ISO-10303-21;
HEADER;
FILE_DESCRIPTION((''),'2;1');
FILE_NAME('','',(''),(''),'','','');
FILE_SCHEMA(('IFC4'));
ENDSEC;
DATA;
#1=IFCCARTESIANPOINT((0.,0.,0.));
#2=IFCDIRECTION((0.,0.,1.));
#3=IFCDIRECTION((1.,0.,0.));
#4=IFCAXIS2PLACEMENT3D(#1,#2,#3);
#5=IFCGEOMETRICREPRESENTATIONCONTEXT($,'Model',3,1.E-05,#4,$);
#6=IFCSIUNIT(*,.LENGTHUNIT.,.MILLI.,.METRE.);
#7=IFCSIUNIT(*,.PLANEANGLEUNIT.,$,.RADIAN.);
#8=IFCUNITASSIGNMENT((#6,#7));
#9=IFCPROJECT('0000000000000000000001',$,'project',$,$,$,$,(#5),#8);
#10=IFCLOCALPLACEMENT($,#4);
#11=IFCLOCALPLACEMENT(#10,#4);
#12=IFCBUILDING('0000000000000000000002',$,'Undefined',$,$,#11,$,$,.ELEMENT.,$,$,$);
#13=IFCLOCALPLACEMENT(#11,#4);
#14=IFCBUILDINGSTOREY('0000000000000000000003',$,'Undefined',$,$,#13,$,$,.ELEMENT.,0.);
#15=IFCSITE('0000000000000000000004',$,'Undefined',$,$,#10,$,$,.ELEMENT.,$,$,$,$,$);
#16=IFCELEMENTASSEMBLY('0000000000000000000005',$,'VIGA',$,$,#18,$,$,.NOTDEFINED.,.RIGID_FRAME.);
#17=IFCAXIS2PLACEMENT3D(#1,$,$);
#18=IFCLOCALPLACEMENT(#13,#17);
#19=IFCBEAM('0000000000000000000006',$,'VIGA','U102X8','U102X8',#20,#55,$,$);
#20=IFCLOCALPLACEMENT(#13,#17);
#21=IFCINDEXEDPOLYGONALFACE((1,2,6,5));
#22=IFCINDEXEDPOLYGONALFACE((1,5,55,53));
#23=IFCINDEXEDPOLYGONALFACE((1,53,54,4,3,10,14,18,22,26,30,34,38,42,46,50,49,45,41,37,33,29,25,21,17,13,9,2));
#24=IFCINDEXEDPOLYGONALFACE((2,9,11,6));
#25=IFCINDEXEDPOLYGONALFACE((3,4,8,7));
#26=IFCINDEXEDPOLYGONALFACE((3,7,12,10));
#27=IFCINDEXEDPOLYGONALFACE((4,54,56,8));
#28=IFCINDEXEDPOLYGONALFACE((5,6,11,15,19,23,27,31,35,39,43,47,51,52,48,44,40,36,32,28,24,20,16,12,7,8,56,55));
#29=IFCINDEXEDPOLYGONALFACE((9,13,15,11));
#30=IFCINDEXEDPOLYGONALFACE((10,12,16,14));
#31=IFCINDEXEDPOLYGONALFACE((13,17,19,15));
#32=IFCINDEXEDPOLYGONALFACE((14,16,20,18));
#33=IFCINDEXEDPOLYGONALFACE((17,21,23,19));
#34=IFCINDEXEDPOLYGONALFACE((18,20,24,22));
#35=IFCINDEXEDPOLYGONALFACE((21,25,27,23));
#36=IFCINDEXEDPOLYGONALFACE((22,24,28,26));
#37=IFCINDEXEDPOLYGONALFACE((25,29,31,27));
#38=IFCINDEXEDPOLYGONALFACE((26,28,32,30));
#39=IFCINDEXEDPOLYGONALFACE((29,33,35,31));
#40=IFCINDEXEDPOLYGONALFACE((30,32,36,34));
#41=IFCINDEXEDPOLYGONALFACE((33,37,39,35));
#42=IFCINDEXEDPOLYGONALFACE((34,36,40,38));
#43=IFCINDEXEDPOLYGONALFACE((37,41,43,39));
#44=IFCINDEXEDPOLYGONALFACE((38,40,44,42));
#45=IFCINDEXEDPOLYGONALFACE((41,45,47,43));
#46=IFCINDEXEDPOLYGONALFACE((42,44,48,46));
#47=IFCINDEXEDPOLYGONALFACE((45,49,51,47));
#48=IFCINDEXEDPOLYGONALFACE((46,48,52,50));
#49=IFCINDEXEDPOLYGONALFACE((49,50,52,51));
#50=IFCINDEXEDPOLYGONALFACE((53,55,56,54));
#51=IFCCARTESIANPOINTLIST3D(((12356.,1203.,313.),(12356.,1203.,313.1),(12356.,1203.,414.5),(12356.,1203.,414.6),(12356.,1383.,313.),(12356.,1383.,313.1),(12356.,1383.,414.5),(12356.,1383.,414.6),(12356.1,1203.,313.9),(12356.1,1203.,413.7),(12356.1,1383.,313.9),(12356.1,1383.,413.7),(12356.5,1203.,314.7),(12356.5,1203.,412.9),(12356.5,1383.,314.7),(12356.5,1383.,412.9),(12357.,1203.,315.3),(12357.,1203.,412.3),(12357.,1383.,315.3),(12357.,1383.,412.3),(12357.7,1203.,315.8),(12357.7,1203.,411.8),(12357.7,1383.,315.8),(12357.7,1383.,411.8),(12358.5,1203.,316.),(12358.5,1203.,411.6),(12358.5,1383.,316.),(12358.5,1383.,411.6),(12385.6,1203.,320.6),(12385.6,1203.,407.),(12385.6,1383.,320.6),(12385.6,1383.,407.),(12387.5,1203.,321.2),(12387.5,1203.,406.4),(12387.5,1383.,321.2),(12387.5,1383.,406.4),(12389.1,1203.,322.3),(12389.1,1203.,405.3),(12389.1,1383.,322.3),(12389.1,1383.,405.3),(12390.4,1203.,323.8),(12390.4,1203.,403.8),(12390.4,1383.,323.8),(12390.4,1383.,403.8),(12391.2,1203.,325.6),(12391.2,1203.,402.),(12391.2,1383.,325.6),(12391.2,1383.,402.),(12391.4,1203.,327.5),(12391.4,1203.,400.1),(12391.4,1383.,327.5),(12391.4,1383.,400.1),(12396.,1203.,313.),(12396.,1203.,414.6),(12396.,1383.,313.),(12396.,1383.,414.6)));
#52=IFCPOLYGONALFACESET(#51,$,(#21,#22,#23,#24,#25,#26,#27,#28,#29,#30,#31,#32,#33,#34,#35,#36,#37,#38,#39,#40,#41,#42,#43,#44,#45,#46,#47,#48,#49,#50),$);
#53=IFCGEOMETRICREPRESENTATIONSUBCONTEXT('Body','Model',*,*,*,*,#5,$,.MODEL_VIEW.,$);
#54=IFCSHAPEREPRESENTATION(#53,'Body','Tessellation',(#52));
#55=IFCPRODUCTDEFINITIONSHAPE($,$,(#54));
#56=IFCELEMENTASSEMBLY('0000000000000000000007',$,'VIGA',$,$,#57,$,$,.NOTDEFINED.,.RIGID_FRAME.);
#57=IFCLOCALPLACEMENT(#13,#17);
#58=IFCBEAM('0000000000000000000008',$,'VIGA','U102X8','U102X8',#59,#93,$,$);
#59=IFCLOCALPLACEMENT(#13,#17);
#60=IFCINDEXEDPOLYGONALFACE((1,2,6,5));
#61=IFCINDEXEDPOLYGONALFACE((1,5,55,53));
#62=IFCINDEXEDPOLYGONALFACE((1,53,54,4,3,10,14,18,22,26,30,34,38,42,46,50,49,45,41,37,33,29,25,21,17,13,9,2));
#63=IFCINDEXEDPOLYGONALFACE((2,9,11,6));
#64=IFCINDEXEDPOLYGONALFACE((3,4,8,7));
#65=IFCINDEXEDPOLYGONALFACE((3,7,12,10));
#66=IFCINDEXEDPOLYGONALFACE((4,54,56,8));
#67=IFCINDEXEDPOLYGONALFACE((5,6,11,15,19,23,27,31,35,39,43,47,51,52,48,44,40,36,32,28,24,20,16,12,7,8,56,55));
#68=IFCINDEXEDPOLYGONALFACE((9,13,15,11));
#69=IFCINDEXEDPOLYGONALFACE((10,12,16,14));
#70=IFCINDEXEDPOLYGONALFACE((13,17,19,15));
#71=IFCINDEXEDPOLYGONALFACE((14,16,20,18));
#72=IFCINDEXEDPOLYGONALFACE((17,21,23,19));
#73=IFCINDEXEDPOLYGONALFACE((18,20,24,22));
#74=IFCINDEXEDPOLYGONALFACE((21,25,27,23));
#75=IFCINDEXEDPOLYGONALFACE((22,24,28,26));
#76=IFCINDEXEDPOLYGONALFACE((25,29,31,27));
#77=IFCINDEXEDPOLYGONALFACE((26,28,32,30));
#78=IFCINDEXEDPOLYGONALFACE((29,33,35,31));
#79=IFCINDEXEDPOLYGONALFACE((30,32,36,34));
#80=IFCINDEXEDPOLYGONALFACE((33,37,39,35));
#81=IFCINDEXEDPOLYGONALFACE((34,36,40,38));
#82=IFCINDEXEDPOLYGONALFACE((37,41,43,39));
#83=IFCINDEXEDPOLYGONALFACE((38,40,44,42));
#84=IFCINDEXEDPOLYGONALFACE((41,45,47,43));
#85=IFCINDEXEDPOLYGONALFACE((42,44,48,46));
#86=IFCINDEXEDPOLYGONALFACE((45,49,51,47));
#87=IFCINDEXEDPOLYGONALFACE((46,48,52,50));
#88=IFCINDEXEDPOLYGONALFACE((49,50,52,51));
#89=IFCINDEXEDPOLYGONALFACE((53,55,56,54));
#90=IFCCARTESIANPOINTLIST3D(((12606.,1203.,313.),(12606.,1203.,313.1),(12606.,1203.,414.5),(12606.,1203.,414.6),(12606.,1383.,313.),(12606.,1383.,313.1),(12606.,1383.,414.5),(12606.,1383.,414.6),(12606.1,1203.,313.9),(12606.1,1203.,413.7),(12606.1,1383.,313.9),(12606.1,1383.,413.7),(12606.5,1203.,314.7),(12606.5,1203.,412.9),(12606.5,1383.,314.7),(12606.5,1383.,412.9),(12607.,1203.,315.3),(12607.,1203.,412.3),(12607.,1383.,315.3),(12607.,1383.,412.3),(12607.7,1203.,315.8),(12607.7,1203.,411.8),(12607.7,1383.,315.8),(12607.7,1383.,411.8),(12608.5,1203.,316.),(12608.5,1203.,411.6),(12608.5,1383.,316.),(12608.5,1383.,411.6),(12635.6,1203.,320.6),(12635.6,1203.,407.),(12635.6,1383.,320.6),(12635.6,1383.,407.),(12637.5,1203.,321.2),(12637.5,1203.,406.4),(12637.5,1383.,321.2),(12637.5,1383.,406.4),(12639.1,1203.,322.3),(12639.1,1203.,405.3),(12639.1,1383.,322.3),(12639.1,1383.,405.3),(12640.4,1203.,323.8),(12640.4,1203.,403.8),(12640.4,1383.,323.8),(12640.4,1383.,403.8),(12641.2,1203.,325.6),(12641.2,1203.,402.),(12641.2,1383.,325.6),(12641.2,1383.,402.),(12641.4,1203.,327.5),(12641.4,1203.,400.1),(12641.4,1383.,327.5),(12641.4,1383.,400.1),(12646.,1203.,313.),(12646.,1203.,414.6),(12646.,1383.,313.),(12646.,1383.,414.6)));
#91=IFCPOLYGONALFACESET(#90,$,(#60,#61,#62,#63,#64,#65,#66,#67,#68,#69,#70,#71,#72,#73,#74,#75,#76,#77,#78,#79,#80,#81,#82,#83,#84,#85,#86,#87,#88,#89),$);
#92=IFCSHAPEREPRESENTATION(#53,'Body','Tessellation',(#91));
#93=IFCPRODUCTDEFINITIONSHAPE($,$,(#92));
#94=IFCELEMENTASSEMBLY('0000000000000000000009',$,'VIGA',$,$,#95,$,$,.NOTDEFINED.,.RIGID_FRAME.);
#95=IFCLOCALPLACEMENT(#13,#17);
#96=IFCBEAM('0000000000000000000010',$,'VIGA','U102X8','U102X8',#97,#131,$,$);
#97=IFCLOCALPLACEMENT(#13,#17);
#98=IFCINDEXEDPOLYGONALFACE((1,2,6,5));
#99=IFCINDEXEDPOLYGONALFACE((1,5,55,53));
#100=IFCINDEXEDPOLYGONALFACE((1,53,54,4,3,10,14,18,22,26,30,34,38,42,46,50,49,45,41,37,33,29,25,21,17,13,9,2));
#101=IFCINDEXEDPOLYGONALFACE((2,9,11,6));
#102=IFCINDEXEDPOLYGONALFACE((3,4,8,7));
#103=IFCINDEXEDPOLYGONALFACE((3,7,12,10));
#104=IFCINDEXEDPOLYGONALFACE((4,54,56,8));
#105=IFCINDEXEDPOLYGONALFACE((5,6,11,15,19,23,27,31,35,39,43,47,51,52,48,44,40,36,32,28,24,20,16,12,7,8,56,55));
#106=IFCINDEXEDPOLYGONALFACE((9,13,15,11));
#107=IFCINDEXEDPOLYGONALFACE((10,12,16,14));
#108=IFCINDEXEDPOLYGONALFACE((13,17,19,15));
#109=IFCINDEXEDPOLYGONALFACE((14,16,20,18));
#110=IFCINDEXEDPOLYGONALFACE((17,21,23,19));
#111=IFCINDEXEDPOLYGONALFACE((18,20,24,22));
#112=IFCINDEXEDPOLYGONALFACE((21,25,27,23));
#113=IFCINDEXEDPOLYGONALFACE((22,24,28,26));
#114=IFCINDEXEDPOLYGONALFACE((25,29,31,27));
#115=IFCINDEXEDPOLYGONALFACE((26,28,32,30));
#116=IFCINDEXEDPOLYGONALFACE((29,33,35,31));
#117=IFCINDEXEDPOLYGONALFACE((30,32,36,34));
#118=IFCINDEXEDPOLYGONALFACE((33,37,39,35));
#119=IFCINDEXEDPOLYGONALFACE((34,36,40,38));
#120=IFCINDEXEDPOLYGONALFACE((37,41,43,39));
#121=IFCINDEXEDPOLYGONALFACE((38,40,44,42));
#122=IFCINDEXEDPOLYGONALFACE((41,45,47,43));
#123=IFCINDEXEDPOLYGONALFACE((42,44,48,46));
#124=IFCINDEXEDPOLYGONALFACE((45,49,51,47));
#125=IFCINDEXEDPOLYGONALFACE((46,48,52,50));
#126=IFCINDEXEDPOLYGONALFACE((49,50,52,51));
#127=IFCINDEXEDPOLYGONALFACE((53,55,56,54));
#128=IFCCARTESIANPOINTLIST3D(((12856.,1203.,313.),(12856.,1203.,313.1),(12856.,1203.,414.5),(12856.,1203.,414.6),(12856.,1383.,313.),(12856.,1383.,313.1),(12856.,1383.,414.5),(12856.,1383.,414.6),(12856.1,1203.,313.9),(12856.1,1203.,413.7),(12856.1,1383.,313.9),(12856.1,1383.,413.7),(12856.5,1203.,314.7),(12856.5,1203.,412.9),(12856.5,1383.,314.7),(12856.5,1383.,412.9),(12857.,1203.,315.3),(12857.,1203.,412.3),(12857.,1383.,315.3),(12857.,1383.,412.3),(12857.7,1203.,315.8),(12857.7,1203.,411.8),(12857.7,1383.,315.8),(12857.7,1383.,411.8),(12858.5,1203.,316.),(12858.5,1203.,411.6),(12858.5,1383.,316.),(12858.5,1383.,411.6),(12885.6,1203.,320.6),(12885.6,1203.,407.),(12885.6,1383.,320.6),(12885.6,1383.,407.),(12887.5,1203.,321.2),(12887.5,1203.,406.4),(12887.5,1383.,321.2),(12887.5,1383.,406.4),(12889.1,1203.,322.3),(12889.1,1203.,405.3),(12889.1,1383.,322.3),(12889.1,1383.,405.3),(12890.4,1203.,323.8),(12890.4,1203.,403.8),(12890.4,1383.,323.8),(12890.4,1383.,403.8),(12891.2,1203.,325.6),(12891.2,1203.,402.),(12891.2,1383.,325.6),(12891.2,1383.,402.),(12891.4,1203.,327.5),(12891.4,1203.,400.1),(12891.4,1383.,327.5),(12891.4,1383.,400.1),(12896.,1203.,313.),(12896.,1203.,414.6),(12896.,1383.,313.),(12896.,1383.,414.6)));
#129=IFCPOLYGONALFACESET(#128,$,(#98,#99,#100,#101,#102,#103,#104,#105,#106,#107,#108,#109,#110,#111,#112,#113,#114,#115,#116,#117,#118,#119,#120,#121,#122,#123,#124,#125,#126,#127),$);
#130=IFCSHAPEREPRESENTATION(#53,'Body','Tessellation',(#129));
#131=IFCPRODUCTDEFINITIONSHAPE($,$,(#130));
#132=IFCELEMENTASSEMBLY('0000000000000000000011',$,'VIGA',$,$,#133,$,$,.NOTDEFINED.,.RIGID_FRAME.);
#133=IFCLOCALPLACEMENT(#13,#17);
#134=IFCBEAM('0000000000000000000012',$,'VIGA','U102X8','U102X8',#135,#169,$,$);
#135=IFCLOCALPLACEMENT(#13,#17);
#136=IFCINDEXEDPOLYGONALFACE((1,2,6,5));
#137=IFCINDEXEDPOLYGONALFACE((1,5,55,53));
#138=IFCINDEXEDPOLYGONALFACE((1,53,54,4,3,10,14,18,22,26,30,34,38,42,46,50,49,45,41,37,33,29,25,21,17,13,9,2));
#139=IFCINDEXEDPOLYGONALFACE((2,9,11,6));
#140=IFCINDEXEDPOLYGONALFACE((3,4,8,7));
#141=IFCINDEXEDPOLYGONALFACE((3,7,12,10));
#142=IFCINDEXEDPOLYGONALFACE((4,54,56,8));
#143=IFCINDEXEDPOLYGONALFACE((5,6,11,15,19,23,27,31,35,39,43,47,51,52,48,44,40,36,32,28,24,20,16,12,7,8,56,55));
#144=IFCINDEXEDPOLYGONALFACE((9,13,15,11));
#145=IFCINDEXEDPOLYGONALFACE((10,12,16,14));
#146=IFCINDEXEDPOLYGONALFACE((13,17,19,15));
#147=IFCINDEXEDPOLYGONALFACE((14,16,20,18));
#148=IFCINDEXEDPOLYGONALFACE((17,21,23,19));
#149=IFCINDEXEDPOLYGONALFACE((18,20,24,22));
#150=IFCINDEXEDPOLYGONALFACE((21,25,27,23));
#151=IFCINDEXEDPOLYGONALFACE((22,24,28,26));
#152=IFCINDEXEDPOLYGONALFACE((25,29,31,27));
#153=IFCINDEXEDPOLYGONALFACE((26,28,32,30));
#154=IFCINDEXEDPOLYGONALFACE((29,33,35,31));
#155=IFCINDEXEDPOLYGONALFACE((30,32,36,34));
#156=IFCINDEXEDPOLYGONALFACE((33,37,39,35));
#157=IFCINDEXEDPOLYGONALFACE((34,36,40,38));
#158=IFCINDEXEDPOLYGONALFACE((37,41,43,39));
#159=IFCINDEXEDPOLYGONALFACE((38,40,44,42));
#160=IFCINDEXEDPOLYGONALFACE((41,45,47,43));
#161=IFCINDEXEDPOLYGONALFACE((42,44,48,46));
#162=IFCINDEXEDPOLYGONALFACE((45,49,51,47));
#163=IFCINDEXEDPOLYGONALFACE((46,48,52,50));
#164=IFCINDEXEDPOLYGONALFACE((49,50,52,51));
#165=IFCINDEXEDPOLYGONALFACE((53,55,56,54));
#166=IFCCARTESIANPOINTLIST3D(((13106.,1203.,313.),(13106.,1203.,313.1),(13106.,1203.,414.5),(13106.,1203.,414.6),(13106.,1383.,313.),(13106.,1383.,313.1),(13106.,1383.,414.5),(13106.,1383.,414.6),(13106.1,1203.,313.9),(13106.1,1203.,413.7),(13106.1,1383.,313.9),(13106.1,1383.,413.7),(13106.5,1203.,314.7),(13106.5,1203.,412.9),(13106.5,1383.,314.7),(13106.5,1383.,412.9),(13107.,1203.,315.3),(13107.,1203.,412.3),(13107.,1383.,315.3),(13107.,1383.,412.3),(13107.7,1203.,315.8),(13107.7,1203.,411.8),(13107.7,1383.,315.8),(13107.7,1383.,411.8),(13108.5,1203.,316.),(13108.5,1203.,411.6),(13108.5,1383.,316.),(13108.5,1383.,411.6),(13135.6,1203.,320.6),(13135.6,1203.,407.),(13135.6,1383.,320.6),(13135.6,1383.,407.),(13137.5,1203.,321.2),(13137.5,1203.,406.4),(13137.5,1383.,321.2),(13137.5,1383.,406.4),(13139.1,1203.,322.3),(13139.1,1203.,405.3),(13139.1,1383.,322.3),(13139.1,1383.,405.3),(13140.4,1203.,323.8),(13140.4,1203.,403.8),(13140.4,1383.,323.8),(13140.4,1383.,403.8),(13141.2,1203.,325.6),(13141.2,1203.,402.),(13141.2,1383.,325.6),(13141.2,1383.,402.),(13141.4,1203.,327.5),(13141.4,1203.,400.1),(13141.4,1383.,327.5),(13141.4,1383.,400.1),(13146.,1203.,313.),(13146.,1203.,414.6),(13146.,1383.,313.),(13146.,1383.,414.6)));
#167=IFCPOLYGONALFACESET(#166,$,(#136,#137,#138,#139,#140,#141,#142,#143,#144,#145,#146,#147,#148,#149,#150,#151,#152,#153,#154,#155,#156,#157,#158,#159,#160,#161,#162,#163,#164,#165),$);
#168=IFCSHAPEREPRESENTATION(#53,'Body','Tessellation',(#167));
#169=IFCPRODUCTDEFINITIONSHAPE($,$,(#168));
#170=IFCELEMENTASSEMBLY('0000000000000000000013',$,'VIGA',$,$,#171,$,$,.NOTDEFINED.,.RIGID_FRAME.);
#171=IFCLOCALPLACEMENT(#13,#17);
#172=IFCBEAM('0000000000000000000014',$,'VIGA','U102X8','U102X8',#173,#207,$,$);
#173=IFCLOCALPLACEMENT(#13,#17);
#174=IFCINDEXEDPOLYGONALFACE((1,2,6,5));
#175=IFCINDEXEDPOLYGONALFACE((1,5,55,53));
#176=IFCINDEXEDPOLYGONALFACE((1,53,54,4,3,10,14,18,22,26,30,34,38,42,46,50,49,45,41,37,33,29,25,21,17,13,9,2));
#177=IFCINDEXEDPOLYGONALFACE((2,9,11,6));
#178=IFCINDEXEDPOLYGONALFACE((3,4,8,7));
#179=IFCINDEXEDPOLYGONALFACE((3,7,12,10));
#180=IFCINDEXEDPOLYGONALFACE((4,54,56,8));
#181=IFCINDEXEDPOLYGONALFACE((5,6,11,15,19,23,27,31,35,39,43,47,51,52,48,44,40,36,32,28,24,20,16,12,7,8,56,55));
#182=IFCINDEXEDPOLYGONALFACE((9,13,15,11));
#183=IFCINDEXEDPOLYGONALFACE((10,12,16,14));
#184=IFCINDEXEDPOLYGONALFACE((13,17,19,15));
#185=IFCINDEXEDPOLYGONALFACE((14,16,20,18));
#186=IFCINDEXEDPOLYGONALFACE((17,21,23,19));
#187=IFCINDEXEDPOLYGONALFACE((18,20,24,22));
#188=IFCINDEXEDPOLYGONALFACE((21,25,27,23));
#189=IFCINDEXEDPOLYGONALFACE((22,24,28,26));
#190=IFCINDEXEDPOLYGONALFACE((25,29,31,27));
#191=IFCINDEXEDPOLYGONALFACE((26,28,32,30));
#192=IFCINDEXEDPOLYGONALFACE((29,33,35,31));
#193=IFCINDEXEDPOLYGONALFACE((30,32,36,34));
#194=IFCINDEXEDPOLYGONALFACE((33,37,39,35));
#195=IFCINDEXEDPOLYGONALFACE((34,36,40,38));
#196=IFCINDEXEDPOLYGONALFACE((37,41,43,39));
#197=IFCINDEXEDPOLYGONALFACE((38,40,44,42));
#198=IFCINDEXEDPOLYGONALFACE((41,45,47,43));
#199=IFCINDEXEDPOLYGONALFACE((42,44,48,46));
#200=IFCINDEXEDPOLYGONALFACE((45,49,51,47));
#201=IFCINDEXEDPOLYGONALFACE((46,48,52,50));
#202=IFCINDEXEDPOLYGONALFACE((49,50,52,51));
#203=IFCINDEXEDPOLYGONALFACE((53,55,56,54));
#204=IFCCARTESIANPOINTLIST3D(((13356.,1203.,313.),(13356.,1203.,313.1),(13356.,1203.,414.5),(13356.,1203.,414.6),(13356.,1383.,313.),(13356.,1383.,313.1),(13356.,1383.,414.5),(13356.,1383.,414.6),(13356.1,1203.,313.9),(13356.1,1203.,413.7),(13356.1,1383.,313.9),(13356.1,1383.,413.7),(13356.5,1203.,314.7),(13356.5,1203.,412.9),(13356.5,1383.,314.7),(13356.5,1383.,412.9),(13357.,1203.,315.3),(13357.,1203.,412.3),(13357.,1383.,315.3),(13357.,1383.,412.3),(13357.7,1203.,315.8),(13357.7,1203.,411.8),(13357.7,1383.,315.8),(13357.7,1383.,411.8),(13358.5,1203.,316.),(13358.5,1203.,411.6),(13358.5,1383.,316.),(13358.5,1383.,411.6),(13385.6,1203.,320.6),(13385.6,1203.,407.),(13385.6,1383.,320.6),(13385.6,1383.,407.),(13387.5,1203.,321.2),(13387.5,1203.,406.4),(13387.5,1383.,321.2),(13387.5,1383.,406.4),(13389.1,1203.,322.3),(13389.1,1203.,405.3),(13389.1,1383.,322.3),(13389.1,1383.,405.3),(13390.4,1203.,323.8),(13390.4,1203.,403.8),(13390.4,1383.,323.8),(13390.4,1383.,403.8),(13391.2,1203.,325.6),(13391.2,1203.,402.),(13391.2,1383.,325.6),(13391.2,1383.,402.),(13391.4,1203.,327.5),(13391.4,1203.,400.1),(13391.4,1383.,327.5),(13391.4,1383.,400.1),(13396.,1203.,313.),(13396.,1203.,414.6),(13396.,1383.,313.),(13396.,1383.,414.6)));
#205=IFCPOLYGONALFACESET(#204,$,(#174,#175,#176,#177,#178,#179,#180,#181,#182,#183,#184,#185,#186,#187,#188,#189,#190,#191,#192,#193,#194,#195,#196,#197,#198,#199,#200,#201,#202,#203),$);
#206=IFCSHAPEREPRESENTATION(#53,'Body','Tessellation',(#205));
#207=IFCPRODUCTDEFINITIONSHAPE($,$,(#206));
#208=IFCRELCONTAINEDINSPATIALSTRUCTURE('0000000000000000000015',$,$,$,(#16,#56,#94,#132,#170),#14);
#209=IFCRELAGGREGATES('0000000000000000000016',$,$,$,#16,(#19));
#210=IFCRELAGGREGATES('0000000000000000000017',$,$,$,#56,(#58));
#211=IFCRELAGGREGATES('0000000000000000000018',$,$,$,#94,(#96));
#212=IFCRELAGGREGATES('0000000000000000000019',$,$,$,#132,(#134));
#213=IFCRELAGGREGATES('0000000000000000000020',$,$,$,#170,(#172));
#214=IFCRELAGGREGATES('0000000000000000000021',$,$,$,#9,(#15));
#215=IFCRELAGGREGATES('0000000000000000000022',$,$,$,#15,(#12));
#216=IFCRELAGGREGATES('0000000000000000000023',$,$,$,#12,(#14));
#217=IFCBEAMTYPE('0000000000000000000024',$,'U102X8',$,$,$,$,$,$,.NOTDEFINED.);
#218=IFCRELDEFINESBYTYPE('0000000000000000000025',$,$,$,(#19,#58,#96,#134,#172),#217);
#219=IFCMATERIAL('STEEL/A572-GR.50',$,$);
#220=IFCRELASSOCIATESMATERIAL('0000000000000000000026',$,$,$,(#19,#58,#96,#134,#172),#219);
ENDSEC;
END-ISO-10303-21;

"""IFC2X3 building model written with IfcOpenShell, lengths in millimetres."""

from ifc_helpers import new_model, si_unit, frame, origin_with_axes, origin_2d_with_axis, place, context, subcontext, project, spatial, u_section, extrude, material, type_object, element, aggregate, save


model = new_model("IFC2X3")

# Units and contexts
model_context = context("Model", 3, precision=1e-05, world=origin_with_axes())
body_context = subcontext(model_context, "Body", "Model", "MODEL_VIEW")
ifc_project = project(units=[si_unit("LENGTHUNIT", "METRE", prefix="MILLI"), si_unit("PLANEANGLEUNIT", "RADIAN")], contexts=[model_context])

# Site, building, storey
site_placement = place(None, origin_with_axes())
site = spatial("IfcSite", under=ifc_project, at=site_placement, Name="Undefined", CompositionType="ELEMENT")
building_placement = place(site_placement, origin_with_axes())
building = spatial("IfcBuilding", under=site, at=building_placement, Name="Undefined", CompositionType="ELEMENT")
storey_placement = place(building_placement, origin_with_axes())
storey = spatial("IfcBuildingStorey", under=building, at=storey_placement, Name="Undefined", CompositionType="ELEMENT", Elevation=0.0)

# Element assemblies, beams
ifc_material = material(Name="STEEL/A572-GR.50")
beam_type = type_object("IfcBeamType", Name="U102X8", PredefinedType="NOTDEFINED")
assembly_1_placement = place(storey_placement, origin_with_axes())
assembly_1 = element("IfcElementAssembly", 1, at=assembly_1_placement, inside=storey, Name="VIGA", AssemblyPlace="NOTDEFINED", PredefinedType="RIGID_FRAME")
beam_1_placement = place(assembly_1_placement, frame((12376.0, 1383.0, 363.8), z_axis=(0.0, 0.0, 1.0), x_axis=(0.0, -1.0, 0.0)))
beam_1 = element("IfcBeam", 2, at=beam_1_placement, type_object=beam_type, material=ifc_material, Name="VIGA", Description="U102X8", ObjectType="U102X8", context=body_context, shape_type="SweptSolid", body=[
    extrude(u_section(Depth=101.6, FlangeWidth=40.0, WebThickness=4.6, FlangeThickness=6.0, FilletRadius=7.0, EdgeRadius=3.0, FlangeSlope=0.16839, at=origin_2d_with_axis()), frame((180.0, 0.0, 0.0), z_axis=(-1.0, 0.0, 0.0), x_axis=(0.0, -1.0, 0.0)), (0.0, 0.0, 1.0), 180.0),
])
aggregate(assembly_1, [beam_1])
assembly_2_placement = place(storey_placement, origin_with_axes())
assembly_2 = element("IfcElementAssembly", 3, at=assembly_2_placement, inside=storey, Name="VIGA", AssemblyPlace="NOTDEFINED", PredefinedType="RIGID_FRAME")
beam_2_placement = place(assembly_2_placement, frame((12626.0, 1383.0, 363.8), z_axis=(0.0, 0.0, 1.0), x_axis=(0.0, -1.0, 0.0)))
beam_2 = element("IfcBeam", 4, at=beam_2_placement, type_object=beam_type, material=ifc_material, Name="VIGA", Description="U102X8", ObjectType="U102X8", context=body_context, shape_type="SweptSolid", body=[
    extrude(u_section(Depth=101.6, FlangeWidth=40.0, WebThickness=4.6, FlangeThickness=6.0, FilletRadius=7.0, EdgeRadius=3.0, FlangeSlope=0.16839, at=origin_2d_with_axis()), frame((180.0, 0.0, 0.0), z_axis=(-1.0, 0.0, 0.0), x_axis=(0.0, -1.0, 0.0)), (0.0, 0.0, 1.0), 180.0),
])
aggregate(assembly_2, [beam_2])
assembly_3_placement = place(storey_placement, origin_with_axes())
assembly_3 = element("IfcElementAssembly", 5, at=assembly_3_placement, inside=storey, Name="VIGA", AssemblyPlace="NOTDEFINED", PredefinedType="RIGID_FRAME")
beam_3_placement = place(assembly_3_placement, frame((12876.0, 1383.0, 363.8), z_axis=(0.0, 0.0, 1.0), x_axis=(0.0, -1.0, 0.0)))
beam_3 = element("IfcBeam", 6, at=beam_3_placement, type_object=beam_type, material=ifc_material, Name="VIGA", Description="U102X8", ObjectType="U102X8", context=body_context, shape_type="SweptSolid", body=[
    extrude(u_section(Depth=101.6, FlangeWidth=40.0, WebThickness=4.6, FlangeThickness=6.0, FilletRadius=7.0, EdgeRadius=3.0, FlangeSlope=0.16839, at=origin_2d_with_axis()), frame((180.0, 0.0, 0.0), z_axis=(-1.0, 0.0, 0.0), x_axis=(0.0, -1.0, 0.0)), (0.0, 0.0, 1.0), 180.0),
])
aggregate(assembly_3, [beam_3])
assembly_4_placement = place(storey_placement, origin_with_axes())
assembly_4 = element("IfcElementAssembly", 7, at=assembly_4_placement, inside=storey, Name="VIGA", AssemblyPlace="NOTDEFINED", PredefinedType="RIGID_FRAME")
beam_4_placement = place(assembly_4_placement, frame((13126.0, 1383.0, 363.8), z_axis=(0.0, 0.0, 1.0), x_axis=(0.0, -1.0, 0.0)))
beam_4 = element("IfcBeam", 8, at=beam_4_placement, type_object=beam_type, material=ifc_material, Name="VIGA", Description="U102X8", ObjectType="U102X8", context=body_context, shape_type="SweptSolid", body=[
    extrude(u_section(Depth=101.6, FlangeWidth=40.0, WebThickness=4.6, FlangeThickness=6.0, FilletRadius=7.0, EdgeRadius=3.0, FlangeSlope=0.16839, at=origin_2d_with_axis()), frame((180.0, 0.0, 0.0), z_axis=(-1.0, 0.0, 0.0), x_axis=(0.0, -1.0, 0.0)), (0.0, 0.0, 1.0), 180.0),
])
aggregate(assembly_4, [beam_4])
assembly_5_placement = place(storey_placement, origin_with_axes())
assembly_5 = element("IfcElementAssembly", 9, at=assembly_5_placement, inside=storey, Name="VIGA", AssemblyPlace="NOTDEFINED", PredefinedType="RIGID_FRAME")
beam_5_placement = place(assembly_5_placement, frame((13376.0, 1383.0, 363.8), z_axis=(0.0, 0.0, 1.0), x_axis=(0.0, -1.0, 0.0)))
beam_5 = element("IfcBeam", 10, at=beam_5_placement, type_object=beam_type, material=ifc_material, Name="VIGA", Description="U102X8", ObjectType="U102X8", context=body_context, shape_type="SweptSolid", body=[
    extrude(u_section(Depth=101.6, FlangeWidth=40.0, WebThickness=4.6, FlangeThickness=6.0, FilletRadius=7.0, EdgeRadius=3.0, FlangeSlope=0.16839, at=origin_2d_with_axis()), frame((180.0, 0.0, 0.0), z_axis=(-1.0, 0.0, 0.0), x_axis=(0.0, -1.0, 0.0)), (0.0, 0.0, 1.0), 180.0),
])
aggregate(assembly_5, [beam_5])

save(model, "model.ifc")
